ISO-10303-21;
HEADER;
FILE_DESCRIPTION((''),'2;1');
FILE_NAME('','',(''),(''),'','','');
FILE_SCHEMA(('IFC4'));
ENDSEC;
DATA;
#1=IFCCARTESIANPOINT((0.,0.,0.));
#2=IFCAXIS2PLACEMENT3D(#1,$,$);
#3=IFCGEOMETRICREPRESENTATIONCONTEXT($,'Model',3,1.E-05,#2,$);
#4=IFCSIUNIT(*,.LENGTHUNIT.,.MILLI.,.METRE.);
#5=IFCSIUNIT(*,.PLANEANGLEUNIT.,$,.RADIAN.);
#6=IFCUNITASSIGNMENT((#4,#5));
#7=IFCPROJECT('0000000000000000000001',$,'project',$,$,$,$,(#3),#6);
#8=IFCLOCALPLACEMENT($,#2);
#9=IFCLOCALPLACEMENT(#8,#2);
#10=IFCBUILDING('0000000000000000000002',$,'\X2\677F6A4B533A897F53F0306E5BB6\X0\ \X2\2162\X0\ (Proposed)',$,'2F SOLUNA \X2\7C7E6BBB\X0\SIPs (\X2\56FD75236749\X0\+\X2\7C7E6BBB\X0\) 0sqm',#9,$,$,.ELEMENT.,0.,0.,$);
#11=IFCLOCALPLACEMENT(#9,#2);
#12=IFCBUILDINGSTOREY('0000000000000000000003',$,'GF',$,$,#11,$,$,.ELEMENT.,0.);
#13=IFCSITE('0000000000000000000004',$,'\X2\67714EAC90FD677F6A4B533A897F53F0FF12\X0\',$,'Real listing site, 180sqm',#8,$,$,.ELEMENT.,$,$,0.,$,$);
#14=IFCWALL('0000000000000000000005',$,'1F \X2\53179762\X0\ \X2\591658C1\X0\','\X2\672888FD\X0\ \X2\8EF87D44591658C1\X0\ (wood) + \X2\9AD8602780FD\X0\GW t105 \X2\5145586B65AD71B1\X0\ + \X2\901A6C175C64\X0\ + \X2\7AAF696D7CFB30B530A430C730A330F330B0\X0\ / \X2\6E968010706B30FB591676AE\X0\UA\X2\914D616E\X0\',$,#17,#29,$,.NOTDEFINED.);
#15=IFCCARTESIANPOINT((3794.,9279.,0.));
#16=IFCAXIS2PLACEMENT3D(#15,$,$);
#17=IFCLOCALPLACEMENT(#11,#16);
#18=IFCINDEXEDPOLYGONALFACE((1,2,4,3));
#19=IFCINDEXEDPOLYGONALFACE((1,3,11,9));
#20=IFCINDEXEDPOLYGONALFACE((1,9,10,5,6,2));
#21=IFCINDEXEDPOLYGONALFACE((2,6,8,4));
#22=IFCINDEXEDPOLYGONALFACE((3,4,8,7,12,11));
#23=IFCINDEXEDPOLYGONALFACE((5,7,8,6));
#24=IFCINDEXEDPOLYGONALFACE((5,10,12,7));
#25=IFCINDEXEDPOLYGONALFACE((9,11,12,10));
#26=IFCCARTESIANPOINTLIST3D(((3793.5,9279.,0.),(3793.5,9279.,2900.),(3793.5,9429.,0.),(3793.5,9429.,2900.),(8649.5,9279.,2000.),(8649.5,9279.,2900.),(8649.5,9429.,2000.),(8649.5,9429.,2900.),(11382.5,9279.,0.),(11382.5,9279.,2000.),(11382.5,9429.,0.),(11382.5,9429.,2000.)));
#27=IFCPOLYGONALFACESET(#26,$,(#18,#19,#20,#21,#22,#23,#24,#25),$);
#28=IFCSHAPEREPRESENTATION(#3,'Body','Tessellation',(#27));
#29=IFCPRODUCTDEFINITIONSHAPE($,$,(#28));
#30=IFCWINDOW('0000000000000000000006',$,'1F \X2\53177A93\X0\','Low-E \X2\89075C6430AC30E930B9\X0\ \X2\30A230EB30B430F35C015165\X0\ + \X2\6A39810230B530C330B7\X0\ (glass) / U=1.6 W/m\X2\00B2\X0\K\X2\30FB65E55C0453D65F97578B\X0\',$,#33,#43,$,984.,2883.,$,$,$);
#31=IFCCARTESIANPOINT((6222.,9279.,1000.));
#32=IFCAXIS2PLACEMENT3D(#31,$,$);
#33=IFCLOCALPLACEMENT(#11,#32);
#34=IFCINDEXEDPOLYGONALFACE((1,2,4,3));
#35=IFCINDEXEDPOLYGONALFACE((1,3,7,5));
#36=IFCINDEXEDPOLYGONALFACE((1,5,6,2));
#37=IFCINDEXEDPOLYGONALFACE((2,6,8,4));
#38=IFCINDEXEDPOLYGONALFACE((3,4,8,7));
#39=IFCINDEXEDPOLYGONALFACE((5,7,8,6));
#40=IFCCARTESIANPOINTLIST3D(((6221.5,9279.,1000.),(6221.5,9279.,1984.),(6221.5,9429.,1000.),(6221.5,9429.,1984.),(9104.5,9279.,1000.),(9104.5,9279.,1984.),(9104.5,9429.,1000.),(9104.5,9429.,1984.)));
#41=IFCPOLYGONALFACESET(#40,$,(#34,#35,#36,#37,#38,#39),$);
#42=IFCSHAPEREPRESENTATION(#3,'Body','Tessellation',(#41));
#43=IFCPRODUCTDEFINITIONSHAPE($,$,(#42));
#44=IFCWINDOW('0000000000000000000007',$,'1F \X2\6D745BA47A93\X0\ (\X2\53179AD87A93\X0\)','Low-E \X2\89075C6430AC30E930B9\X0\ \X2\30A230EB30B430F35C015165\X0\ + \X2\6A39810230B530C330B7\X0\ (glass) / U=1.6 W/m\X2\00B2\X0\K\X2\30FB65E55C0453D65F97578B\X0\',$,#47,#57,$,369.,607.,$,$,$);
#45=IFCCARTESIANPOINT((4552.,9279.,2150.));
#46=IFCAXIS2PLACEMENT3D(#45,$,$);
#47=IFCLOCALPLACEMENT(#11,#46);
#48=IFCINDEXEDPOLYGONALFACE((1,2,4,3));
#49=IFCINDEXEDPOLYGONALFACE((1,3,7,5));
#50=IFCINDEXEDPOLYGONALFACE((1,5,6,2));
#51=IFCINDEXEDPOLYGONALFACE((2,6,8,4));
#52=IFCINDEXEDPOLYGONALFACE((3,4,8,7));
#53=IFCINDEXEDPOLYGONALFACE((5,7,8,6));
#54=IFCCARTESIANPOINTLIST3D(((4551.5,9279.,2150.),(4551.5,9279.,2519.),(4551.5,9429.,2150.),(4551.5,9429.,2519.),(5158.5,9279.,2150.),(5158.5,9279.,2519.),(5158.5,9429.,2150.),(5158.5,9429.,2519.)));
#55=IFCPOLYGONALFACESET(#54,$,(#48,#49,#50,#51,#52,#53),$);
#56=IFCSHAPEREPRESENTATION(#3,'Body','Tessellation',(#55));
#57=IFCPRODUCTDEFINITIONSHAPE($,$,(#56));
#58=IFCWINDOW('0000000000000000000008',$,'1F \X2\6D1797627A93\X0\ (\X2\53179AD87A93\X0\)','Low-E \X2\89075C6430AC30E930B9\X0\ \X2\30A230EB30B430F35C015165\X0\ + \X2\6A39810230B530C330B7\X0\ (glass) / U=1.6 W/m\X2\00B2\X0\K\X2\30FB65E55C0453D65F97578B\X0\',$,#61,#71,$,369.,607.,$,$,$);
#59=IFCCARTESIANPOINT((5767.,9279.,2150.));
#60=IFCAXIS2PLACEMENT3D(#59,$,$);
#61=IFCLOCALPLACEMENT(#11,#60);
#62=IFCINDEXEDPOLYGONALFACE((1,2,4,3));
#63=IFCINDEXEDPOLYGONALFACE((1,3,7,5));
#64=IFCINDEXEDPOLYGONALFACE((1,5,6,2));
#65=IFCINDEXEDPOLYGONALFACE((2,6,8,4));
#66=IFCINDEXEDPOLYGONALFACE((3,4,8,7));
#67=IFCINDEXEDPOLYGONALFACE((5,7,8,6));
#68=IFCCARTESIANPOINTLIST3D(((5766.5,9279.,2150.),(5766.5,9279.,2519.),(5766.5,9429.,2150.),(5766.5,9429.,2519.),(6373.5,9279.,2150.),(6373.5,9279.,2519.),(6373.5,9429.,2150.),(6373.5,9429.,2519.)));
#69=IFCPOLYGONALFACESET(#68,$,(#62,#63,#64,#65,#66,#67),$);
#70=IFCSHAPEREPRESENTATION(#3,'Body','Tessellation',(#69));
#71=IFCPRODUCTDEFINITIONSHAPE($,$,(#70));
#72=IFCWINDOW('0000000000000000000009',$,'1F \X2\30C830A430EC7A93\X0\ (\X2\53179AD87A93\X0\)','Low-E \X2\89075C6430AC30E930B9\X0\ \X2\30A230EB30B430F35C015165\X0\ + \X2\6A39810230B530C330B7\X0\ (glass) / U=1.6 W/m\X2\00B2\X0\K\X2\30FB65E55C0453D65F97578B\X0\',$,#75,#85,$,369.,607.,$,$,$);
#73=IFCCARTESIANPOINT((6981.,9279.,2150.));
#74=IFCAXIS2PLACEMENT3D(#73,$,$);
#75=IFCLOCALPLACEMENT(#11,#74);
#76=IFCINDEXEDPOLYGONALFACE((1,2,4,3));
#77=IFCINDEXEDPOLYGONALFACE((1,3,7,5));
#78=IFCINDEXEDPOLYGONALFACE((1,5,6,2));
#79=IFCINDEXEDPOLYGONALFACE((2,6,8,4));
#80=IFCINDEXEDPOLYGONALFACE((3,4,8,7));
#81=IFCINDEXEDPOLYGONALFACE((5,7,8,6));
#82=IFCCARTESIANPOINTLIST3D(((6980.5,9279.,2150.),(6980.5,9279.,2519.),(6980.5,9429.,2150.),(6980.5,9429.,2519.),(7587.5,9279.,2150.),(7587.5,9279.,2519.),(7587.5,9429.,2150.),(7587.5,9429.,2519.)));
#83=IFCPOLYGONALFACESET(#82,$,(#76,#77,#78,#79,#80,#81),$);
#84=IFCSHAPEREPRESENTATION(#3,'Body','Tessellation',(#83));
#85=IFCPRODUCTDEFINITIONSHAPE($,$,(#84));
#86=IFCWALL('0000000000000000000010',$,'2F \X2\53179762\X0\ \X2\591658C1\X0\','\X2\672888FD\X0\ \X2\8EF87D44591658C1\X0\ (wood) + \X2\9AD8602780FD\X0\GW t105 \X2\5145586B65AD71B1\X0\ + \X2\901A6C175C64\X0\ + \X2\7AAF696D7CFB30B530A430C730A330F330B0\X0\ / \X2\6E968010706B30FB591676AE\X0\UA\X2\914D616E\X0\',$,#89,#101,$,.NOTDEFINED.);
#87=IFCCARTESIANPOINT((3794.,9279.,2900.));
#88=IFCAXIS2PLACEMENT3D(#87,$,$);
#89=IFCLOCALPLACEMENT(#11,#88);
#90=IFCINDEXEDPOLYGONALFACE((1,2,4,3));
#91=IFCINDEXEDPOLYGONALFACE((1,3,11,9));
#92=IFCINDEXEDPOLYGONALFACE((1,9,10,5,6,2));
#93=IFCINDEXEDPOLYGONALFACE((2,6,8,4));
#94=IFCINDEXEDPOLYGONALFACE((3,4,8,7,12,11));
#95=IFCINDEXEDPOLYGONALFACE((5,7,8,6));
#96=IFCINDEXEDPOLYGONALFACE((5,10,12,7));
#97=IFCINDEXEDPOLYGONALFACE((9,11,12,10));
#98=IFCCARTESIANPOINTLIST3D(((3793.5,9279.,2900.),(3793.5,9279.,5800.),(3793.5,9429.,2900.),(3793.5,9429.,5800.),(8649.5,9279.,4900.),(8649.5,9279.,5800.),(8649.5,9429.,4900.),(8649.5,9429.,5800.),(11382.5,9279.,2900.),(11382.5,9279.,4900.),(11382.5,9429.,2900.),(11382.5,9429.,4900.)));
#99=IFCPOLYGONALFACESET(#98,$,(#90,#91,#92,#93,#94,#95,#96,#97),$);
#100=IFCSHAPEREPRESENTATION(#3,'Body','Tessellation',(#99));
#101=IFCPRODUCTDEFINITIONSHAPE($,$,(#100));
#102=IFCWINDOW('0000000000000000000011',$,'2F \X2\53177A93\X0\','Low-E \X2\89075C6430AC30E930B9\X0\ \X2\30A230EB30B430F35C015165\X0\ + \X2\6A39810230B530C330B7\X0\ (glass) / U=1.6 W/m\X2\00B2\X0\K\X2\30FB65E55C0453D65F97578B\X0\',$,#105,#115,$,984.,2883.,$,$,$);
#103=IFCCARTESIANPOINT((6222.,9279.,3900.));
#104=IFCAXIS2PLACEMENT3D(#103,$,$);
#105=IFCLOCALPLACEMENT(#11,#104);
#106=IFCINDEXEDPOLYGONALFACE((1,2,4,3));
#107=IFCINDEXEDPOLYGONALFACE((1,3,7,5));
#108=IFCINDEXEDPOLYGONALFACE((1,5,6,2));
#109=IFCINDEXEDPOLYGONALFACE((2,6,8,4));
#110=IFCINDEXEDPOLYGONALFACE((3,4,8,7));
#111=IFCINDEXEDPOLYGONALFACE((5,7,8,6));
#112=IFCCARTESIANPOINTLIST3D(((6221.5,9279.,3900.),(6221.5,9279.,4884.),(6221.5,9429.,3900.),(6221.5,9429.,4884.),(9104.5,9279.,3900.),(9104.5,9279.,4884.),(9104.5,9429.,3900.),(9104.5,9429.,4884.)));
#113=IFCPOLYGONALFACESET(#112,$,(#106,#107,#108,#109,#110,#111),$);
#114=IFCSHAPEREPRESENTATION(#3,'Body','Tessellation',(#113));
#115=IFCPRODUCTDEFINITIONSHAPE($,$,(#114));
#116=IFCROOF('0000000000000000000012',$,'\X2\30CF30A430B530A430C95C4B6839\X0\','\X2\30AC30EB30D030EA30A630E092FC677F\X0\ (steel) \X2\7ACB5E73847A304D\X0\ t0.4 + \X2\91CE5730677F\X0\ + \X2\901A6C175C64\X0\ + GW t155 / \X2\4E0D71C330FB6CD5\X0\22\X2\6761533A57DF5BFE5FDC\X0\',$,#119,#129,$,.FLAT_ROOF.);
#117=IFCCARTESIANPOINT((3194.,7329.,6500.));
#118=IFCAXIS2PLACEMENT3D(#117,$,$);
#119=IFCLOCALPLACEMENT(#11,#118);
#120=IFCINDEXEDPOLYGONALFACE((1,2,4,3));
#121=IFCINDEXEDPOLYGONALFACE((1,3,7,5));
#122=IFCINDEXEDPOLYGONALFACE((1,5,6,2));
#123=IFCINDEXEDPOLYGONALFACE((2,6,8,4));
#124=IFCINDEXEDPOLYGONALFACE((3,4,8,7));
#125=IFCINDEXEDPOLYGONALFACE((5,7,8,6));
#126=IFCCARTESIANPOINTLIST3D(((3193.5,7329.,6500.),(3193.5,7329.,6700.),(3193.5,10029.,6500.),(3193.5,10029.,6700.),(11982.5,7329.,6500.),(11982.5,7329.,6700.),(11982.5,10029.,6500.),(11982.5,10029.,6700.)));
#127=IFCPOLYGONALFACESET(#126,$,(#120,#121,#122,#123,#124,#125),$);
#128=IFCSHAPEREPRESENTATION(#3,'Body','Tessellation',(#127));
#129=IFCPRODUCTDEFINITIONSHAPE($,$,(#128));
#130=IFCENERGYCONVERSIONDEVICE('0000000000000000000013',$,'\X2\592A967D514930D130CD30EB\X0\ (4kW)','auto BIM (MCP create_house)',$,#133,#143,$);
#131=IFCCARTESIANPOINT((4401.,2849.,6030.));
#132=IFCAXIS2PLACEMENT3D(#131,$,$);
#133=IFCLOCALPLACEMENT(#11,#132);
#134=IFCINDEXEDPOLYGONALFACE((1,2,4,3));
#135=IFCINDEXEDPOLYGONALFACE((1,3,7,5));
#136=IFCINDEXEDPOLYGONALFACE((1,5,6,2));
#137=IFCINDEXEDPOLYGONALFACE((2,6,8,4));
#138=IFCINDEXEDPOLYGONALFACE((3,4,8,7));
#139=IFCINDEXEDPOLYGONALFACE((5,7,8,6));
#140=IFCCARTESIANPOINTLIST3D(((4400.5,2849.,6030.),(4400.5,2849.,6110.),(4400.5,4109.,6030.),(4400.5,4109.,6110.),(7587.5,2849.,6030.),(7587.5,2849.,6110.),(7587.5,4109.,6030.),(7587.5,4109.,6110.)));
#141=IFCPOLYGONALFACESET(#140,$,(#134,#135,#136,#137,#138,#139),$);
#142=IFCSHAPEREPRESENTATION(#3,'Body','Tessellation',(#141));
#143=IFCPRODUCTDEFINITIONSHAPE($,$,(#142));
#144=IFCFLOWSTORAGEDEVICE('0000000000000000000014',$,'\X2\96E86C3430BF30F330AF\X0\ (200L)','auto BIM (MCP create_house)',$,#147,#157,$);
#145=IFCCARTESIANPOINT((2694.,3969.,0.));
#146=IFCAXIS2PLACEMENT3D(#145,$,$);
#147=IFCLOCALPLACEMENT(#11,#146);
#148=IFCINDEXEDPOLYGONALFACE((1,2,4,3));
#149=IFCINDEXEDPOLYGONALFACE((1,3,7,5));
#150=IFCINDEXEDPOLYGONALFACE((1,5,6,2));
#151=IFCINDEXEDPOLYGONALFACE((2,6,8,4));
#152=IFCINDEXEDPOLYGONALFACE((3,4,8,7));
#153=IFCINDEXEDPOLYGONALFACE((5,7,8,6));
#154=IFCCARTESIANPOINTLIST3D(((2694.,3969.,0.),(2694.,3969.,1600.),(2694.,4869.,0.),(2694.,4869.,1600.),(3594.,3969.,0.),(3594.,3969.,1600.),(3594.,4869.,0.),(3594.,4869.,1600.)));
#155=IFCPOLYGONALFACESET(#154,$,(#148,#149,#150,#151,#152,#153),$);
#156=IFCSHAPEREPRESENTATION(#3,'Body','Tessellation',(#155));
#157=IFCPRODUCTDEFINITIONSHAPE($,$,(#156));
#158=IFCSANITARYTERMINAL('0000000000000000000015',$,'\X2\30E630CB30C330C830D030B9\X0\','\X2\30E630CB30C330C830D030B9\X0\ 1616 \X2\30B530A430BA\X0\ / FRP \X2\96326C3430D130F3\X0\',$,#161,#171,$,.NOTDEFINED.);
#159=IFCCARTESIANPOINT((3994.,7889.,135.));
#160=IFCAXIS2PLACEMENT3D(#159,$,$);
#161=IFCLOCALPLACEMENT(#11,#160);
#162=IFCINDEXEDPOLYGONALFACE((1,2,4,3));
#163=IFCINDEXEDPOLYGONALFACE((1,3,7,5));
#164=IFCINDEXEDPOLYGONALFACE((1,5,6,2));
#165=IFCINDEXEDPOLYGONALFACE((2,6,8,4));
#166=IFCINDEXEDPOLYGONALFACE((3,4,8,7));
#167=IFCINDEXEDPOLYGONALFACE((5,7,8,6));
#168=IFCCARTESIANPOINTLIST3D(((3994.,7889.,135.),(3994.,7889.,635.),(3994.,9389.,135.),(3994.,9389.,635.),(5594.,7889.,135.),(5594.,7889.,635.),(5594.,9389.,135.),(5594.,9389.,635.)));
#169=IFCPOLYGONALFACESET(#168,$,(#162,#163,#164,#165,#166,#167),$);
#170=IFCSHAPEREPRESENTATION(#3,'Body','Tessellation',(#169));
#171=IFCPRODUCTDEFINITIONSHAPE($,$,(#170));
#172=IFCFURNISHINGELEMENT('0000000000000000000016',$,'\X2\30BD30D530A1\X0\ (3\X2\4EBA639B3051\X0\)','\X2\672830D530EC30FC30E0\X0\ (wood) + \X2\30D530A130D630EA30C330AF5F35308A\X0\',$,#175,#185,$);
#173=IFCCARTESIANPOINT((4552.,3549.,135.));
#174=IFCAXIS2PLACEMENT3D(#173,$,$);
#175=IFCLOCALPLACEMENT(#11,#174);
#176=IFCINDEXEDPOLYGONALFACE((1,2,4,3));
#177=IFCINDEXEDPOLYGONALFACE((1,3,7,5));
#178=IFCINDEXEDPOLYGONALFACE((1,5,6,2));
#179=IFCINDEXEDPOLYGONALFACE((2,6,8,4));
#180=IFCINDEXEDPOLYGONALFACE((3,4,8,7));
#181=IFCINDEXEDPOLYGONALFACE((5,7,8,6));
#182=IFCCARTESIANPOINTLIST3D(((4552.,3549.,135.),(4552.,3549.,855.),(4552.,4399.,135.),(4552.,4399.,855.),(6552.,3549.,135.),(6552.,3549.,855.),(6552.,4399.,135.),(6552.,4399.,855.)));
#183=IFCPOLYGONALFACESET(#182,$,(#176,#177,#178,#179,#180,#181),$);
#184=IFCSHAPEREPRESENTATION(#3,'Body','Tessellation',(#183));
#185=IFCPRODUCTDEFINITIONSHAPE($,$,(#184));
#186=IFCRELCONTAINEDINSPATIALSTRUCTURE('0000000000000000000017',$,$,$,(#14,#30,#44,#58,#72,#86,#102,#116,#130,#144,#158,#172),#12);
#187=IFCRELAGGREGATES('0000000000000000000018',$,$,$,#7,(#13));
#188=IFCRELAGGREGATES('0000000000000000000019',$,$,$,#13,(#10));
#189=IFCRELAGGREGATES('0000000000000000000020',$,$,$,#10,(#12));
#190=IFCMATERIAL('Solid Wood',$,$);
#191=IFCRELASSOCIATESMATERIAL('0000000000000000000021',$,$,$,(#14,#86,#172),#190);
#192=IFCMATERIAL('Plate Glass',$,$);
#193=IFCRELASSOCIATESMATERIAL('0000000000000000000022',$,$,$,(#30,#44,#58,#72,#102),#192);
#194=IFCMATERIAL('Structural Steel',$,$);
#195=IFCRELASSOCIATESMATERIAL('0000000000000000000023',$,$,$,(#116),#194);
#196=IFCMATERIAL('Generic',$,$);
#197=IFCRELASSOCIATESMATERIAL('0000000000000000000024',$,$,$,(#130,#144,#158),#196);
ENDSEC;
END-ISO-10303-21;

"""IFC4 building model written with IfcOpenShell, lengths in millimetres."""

from ifc_helpers import new_model, si_unit, frame, frame_2d, origin, place, context, project, spatial, rectangle, extrude, material, element, fill, save


model = new_model("IFC4")

# Units and contexts
model_context = context("Model", 3, precision=1e-05, world=origin())
ifc_project = project(units=[si_unit("LENGTHUNIT", "METRE", prefix="MILLI"), si_unit("PLANEANGLEUNIT", "RADIAN")], contexts=[model_context])

# Site, building, storey
site_placement = place(None, origin())
site = spatial("IfcSite", under=ifc_project, at=site_placement, Name="東京都板橋区西台２", ObjectType="Real listing site, 180sqm", CompositionType="ELEMENT", RefElevation=0.0)
building_placement = place(site_placement, origin())
building = spatial("IfcBuilding", under=site, at=building_placement, Name="板橋区西台の家 Ⅲ (Proposed)", ObjectType="2F SOLUNA 籾殻SIPs (国産杉+籾殻) 0sqm", CompositionType="ELEMENT", ElevationOfRefHeight=0.0, ElevationOfTerrain=0.0)
storey_placement = place(building_placement, origin())
storey = spatial("IfcBuildingStorey", under=building, at=storey_placement, Name="GF", CompositionType="ELEMENT", Elevation=0.0)

# Wall, openings, windows
ifc_material_1 = material(Name="Solid Wood")
wall_1_placement = place(storey_placement, frame((3794.0, 9279.0, 0.0)))
wall_1 = element("IfcWall", 1, at=wall_1_placement, inside=storey, material=ifc_material_1, Name="1F 北面 外壁", Description="木製 軸組外壁 (wood) + 高性能GW t105 充填断熱 + 通気層 + 窯業系サイディング / 準耐火・外皮UA配慮", PredefinedType="NOTDEFINED", context=model_context, shape_type="SweptSolid", body=[
    extrude(rectangle(XDim=7589.0, YDim=150.0, at=frame_2d((3794.0, 75.0))), frame((3794.0, 9279.0, 0.0)), (0.0, 0.0, 1.0), 2900.0),
])
opening_1_placement = place(storey_placement, frame((6222.0, 9279.0, 1000.0)))
opening_1 = element("IfcOpeningElement", 2, at=opening_1_placement, cuts=wall_1, PredefinedType="NOTDEFINED", context=model_context, shape_type="SweptSolid", body=[
    extrude(rectangle(XDim=2883.0, YDim=150.0, at=frame_2d((1441.0, 75.0))), frame((6222.0, 9279.0, 1000.0)), (0.0, 0.0, 1.0), 984.0),
])
opening_2_placement = place(storey_placement, frame((4552.0, 9279.0, 2150.0)))
opening_2 = element("IfcOpeningElement", 3, at=opening_2_placement, cuts=wall_1, PredefinedType="NOTDEFINED", context=model_context, shape_type="SweptSolid", body=[
    extrude(rectangle(XDim=607.0, YDim=150.0, at=frame_2d((303.0, 75.0))), frame((4552.0, 9279.0, 2150.0)), (0.0, 0.0, 1.0), 369.0),
])
opening_3_placement = place(storey_placement, frame((5767.0, 9279.0, 2150.0)))
opening_3 = element("IfcOpeningElement", 4, at=opening_3_placement, cuts=wall_1, PredefinedType="NOTDEFINED", context=model_context, shape_type="SweptSolid", body=[
    extrude(rectangle(XDim=607.0, YDim=150.0, at=frame_2d((303.0, 75.0))), frame((5767.0, 9279.0, 2150.0)), (0.0, 0.0, 1.0), 369.0),
])
opening_4_placement = place(storey_placement, frame((6981.0, 9279.0, 2150.0)))
opening_4 = element("IfcOpeningElement", 5, at=opening_4_placement, cuts=wall_1, PredefinedType="NOTDEFINED", context=model_context, shape_type="SweptSolid", body=[
    extrude(rectangle(XDim=607.0, YDim=150.0, at=frame_2d((303.0, 75.0))), frame((6981.0, 9279.0, 2150.0)), (0.0, 0.0, 1.0), 369.0),
])
ifc_material_2 = material(Name="Plate Glass")
window_1_placement = place(storey_placement, frame((6222.0, 9279.0, 1000.0)))
window_1 = element("IfcWindow", 6, at=window_1_placement, inside=storey, material=ifc_material_2, Name="1F 北窓", Description="Low-E 複層ガラス アルゴン封入 + 樹脂サッシ (glass) / U=1.6 W/m²K・日射取得型", OverallHeight=984.0, OverallWidth=2883.0, context=model_context, shape_type="SweptSolid", body=[
    extrude(rectangle(XDim=2883.0, YDim=150.0, at=frame_2d((1441.0, 75.0))), frame((6222.0, 9279.0, 1000.0)), (0.0, 0.0, 1.0), 984.0),
])
fill(opening_1, window_1)
window_2_placement = place(storey_placement, frame((4552.0, 9279.0, 2150.0)))
window_2 = element("IfcWindow", 7, at=window_2_placement, inside=storey, material=ifc_material_2, Name="1F 浴室窓 (北高窓)", Description="Low-E 複層ガラス アルゴン封入 + 樹脂サッシ (glass) / U=1.6 W/m²K・日射取得型", OverallHeight=369.0, OverallWidth=607.0, context=model_context, shape_type="SweptSolid", body=[
    extrude(rectangle(XDim=607.0, YDim=150.0, at=frame_2d((303.0, 75.0))), frame((4552.0, 9279.0, 2150.0)), (0.0, 0.0, 1.0), 369.0),
])
fill(opening_2, window_2)
window_3_placement = place(storey_placement, frame((5767.0, 9279.0, 2150.0)))
window_3 = element("IfcWindow", 8, at=window_3_placement, inside=storey, material=ifc_material_2, Name="1F 洗面窓 (北高窓)", Description="Low-E 複層ガラス アルゴン封入 + 樹脂サッシ (glass) / U=1.6 W/m²K・日射取得型", OverallHeight=369.0, OverallWidth=607.0, context=model_context, shape_type="SweptSolid", body=[
    extrude(rectangle(XDim=607.0, YDim=150.0, at=frame_2d((303.0, 75.0))), frame((5767.0, 9279.0, 2150.0)), (0.0, 0.0, 1.0), 369.0),
])
fill(opening_3, window_3)
window_4_placement = place(storey_placement, frame((6981.0, 9279.0, 2150.0)))
window_4 = element("IfcWindow", 9, at=window_4_placement, inside=storey, material=ifc_material_2, Name="1F トイレ窓 (北高窓)", Description="Low-E 複層ガラス アルゴン封入 + 樹脂サッシ (glass) / U=1.6 W/m²K・日射取得型", OverallHeight=369.0, OverallWidth=607.0, context=model_context, shape_type="SweptSolid", body=[
    extrude(rectangle(XDim=607.0, YDim=150.0, at=frame_2d((303.0, 75.0))), frame((6981.0, 9279.0, 2150.0)), (0.0, 0.0, 1.0), 369.0),
])
fill(opening_4, window_4)

# Wall, opening, window
wall_2_placement = place(storey_placement, frame((3794.0, 9279.0, 2900.0)))
wall_2 = element("IfcWall", 10, at=wall_2_placement, inside=storey, material=ifc_material_1, Name="2F 北面 外壁", Description="木製 軸組外壁 (wood) + 高性能GW t105 充填断熱 + 通気層 + 窯業系サイディング / 準耐火・外皮UA配慮", PredefinedType="NOTDEFINED", context=model_context, shape_type="SweptSolid", body=[
    extrude(rectangle(XDim=7589.0, YDim=150.0, at=frame_2d((3794.0, 75.0))), frame((3794.0, 9279.0, 2900.0)), (0.0, 0.0, 1.0), 2900.0),
])
opening_5_placement = place(storey_placement, frame((6222.0, 9279.0, 3900.0)))
opening_5 = element("IfcOpeningElement", 11, at=opening_5_placement, cuts=wall_2, PredefinedType="NOTDEFINED", context=model_context, shape_type="SweptSolid", body=[
    extrude(rectangle(XDim=2883.0, YDim=150.0, at=frame_2d((1441.0, 75.0))), frame((6222.0, 9279.0, 3900.0)), (0.0, 0.0, 1.0), 984.0),
])
window_5_placement = place(storey_placement, frame((6222.0, 9279.0, 3900.0)))
window_5 = element("IfcWindow", 12, at=window_5_placement, inside=storey, material=ifc_material_2, Name="2F 北窓", Description="Low-E 複層ガラス アルゴン封入 + 樹脂サッシ (glass) / U=1.6 W/m²K・日射取得型", OverallHeight=984.0, OverallWidth=2883.0, context=model_context, shape_type="SweptSolid", body=[
    extrude(rectangle(XDim=2883.0, YDim=150.0, at=frame_2d((1441.0, 75.0))), frame((6222.0, 9279.0, 3900.0)), (0.0, 0.0, 1.0), 984.0),
])
fill(opening_5, window_5)

# Roof
ifc_material_3 = material(Name="Structural Steel")
roof_placement = place(storey_placement, frame((3194.0, 7329.0, 6500.0)))
element("IfcRoof", 13, at=roof_placement, inside=storey, material=ifc_material_3, Name="ハイサイド屋根", Description="ガルバリウム鋼板 (steel) 立平葺き t0.4 + 野地板 + 通気層 + GW t155 / 不燃・法22条区域対応", PredefinedType="FLAT_ROOF", context=model_context, shape_type="SweptSolid", body=[
    extrude(rectangle(XDim=8789.0, YDim=2700.0, at=frame_2d((4394.0, 1350.0))), frame((3194.0, 7329.0, 6500.0)), (0.0, 0.0, 1.0), 200.0),
])

# Energy conversion device
ifc_material_4 = material(Name="Generic")
energy_conversion_device_placement = place(storey_placement, frame((4401.0, 2849.0, 6030.0)))
element("IfcEnergyConversionDevice", 14, at=energy_conversion_device_placement, inside=storey, material=ifc_material_4, Name="太陽光パネル (4kW)", Description="auto BIM (MCP create_house)", context=model_context, shape_type="SweptSolid", body=[
    extrude(rectangle(XDim=3187.0, YDim=1260.0, at=frame_2d((1593.0, 630.0))), frame((4401.0, 2849.0, 6030.0)), (0.0, 0.0, 1.0), 80.0),
])

# Flow storage device
flow_storage_device_placement = place(storey_placement, frame((2694.0, 3969.0, 0.0)))
element("IfcFlowStorageDevice", 15, at=flow_storage_device_placement, inside=storey, material=ifc_material_4, Name="雨水タンク (200L)", Description="auto BIM (MCP create_house)", context=model_context, shape_type="SweptSolid", body=[
    extrude(rectangle(XDim=900.0, YDim=900.0, at=frame_2d((450.0, 450.0))), frame((2694.0, 3969.0, 0.0)), (0.0, 0.0, 1.0), 1600.0),
])

# Sanitary terminal
sanitary_terminal_placement = place(storey_placement, frame((3994.0, 7889.0, 135.0)))
element("IfcSanitaryTerminal", 16, at=sanitary_terminal_placement, inside=storey, material=ifc_material_4, Name="ユニットバス", Description="ユニットバス 1616 サイズ / FRP 防水パン", PredefinedType="NOTDEFINED", context=model_context, shape_type="SweptSolid", body=[
    extrude(rectangle(XDim=1600.0, YDim=1500.0, at=frame_2d((800.0, 750.0))), frame((3994.0, 7889.0, 135.0)), (0.0, 0.0, 1.0), 500.0),
])

# Furnishing element
furnishing_1_placement = place(storey_placement, frame((4552.0, 3549.0, 135.0)))
element("IfcFurnishingElement", 17, at=furnishing_1_placement, inside=storey, material=ifc_material_1, Name="ソファ (3人掛け)", Description="木フレーム (wood) + ファブリック張り", context=model_context, shape_type="SweptSolid", body=[
    extrude(rectangle(XDim=2000.0, YDim=850.0, at=frame_2d((1000.0, 425.0))), frame((4552.0, 3549.0, 135.0)), (0.0, 0.0, 1.0), 720.0),
])

save(model, "model.ifc")
